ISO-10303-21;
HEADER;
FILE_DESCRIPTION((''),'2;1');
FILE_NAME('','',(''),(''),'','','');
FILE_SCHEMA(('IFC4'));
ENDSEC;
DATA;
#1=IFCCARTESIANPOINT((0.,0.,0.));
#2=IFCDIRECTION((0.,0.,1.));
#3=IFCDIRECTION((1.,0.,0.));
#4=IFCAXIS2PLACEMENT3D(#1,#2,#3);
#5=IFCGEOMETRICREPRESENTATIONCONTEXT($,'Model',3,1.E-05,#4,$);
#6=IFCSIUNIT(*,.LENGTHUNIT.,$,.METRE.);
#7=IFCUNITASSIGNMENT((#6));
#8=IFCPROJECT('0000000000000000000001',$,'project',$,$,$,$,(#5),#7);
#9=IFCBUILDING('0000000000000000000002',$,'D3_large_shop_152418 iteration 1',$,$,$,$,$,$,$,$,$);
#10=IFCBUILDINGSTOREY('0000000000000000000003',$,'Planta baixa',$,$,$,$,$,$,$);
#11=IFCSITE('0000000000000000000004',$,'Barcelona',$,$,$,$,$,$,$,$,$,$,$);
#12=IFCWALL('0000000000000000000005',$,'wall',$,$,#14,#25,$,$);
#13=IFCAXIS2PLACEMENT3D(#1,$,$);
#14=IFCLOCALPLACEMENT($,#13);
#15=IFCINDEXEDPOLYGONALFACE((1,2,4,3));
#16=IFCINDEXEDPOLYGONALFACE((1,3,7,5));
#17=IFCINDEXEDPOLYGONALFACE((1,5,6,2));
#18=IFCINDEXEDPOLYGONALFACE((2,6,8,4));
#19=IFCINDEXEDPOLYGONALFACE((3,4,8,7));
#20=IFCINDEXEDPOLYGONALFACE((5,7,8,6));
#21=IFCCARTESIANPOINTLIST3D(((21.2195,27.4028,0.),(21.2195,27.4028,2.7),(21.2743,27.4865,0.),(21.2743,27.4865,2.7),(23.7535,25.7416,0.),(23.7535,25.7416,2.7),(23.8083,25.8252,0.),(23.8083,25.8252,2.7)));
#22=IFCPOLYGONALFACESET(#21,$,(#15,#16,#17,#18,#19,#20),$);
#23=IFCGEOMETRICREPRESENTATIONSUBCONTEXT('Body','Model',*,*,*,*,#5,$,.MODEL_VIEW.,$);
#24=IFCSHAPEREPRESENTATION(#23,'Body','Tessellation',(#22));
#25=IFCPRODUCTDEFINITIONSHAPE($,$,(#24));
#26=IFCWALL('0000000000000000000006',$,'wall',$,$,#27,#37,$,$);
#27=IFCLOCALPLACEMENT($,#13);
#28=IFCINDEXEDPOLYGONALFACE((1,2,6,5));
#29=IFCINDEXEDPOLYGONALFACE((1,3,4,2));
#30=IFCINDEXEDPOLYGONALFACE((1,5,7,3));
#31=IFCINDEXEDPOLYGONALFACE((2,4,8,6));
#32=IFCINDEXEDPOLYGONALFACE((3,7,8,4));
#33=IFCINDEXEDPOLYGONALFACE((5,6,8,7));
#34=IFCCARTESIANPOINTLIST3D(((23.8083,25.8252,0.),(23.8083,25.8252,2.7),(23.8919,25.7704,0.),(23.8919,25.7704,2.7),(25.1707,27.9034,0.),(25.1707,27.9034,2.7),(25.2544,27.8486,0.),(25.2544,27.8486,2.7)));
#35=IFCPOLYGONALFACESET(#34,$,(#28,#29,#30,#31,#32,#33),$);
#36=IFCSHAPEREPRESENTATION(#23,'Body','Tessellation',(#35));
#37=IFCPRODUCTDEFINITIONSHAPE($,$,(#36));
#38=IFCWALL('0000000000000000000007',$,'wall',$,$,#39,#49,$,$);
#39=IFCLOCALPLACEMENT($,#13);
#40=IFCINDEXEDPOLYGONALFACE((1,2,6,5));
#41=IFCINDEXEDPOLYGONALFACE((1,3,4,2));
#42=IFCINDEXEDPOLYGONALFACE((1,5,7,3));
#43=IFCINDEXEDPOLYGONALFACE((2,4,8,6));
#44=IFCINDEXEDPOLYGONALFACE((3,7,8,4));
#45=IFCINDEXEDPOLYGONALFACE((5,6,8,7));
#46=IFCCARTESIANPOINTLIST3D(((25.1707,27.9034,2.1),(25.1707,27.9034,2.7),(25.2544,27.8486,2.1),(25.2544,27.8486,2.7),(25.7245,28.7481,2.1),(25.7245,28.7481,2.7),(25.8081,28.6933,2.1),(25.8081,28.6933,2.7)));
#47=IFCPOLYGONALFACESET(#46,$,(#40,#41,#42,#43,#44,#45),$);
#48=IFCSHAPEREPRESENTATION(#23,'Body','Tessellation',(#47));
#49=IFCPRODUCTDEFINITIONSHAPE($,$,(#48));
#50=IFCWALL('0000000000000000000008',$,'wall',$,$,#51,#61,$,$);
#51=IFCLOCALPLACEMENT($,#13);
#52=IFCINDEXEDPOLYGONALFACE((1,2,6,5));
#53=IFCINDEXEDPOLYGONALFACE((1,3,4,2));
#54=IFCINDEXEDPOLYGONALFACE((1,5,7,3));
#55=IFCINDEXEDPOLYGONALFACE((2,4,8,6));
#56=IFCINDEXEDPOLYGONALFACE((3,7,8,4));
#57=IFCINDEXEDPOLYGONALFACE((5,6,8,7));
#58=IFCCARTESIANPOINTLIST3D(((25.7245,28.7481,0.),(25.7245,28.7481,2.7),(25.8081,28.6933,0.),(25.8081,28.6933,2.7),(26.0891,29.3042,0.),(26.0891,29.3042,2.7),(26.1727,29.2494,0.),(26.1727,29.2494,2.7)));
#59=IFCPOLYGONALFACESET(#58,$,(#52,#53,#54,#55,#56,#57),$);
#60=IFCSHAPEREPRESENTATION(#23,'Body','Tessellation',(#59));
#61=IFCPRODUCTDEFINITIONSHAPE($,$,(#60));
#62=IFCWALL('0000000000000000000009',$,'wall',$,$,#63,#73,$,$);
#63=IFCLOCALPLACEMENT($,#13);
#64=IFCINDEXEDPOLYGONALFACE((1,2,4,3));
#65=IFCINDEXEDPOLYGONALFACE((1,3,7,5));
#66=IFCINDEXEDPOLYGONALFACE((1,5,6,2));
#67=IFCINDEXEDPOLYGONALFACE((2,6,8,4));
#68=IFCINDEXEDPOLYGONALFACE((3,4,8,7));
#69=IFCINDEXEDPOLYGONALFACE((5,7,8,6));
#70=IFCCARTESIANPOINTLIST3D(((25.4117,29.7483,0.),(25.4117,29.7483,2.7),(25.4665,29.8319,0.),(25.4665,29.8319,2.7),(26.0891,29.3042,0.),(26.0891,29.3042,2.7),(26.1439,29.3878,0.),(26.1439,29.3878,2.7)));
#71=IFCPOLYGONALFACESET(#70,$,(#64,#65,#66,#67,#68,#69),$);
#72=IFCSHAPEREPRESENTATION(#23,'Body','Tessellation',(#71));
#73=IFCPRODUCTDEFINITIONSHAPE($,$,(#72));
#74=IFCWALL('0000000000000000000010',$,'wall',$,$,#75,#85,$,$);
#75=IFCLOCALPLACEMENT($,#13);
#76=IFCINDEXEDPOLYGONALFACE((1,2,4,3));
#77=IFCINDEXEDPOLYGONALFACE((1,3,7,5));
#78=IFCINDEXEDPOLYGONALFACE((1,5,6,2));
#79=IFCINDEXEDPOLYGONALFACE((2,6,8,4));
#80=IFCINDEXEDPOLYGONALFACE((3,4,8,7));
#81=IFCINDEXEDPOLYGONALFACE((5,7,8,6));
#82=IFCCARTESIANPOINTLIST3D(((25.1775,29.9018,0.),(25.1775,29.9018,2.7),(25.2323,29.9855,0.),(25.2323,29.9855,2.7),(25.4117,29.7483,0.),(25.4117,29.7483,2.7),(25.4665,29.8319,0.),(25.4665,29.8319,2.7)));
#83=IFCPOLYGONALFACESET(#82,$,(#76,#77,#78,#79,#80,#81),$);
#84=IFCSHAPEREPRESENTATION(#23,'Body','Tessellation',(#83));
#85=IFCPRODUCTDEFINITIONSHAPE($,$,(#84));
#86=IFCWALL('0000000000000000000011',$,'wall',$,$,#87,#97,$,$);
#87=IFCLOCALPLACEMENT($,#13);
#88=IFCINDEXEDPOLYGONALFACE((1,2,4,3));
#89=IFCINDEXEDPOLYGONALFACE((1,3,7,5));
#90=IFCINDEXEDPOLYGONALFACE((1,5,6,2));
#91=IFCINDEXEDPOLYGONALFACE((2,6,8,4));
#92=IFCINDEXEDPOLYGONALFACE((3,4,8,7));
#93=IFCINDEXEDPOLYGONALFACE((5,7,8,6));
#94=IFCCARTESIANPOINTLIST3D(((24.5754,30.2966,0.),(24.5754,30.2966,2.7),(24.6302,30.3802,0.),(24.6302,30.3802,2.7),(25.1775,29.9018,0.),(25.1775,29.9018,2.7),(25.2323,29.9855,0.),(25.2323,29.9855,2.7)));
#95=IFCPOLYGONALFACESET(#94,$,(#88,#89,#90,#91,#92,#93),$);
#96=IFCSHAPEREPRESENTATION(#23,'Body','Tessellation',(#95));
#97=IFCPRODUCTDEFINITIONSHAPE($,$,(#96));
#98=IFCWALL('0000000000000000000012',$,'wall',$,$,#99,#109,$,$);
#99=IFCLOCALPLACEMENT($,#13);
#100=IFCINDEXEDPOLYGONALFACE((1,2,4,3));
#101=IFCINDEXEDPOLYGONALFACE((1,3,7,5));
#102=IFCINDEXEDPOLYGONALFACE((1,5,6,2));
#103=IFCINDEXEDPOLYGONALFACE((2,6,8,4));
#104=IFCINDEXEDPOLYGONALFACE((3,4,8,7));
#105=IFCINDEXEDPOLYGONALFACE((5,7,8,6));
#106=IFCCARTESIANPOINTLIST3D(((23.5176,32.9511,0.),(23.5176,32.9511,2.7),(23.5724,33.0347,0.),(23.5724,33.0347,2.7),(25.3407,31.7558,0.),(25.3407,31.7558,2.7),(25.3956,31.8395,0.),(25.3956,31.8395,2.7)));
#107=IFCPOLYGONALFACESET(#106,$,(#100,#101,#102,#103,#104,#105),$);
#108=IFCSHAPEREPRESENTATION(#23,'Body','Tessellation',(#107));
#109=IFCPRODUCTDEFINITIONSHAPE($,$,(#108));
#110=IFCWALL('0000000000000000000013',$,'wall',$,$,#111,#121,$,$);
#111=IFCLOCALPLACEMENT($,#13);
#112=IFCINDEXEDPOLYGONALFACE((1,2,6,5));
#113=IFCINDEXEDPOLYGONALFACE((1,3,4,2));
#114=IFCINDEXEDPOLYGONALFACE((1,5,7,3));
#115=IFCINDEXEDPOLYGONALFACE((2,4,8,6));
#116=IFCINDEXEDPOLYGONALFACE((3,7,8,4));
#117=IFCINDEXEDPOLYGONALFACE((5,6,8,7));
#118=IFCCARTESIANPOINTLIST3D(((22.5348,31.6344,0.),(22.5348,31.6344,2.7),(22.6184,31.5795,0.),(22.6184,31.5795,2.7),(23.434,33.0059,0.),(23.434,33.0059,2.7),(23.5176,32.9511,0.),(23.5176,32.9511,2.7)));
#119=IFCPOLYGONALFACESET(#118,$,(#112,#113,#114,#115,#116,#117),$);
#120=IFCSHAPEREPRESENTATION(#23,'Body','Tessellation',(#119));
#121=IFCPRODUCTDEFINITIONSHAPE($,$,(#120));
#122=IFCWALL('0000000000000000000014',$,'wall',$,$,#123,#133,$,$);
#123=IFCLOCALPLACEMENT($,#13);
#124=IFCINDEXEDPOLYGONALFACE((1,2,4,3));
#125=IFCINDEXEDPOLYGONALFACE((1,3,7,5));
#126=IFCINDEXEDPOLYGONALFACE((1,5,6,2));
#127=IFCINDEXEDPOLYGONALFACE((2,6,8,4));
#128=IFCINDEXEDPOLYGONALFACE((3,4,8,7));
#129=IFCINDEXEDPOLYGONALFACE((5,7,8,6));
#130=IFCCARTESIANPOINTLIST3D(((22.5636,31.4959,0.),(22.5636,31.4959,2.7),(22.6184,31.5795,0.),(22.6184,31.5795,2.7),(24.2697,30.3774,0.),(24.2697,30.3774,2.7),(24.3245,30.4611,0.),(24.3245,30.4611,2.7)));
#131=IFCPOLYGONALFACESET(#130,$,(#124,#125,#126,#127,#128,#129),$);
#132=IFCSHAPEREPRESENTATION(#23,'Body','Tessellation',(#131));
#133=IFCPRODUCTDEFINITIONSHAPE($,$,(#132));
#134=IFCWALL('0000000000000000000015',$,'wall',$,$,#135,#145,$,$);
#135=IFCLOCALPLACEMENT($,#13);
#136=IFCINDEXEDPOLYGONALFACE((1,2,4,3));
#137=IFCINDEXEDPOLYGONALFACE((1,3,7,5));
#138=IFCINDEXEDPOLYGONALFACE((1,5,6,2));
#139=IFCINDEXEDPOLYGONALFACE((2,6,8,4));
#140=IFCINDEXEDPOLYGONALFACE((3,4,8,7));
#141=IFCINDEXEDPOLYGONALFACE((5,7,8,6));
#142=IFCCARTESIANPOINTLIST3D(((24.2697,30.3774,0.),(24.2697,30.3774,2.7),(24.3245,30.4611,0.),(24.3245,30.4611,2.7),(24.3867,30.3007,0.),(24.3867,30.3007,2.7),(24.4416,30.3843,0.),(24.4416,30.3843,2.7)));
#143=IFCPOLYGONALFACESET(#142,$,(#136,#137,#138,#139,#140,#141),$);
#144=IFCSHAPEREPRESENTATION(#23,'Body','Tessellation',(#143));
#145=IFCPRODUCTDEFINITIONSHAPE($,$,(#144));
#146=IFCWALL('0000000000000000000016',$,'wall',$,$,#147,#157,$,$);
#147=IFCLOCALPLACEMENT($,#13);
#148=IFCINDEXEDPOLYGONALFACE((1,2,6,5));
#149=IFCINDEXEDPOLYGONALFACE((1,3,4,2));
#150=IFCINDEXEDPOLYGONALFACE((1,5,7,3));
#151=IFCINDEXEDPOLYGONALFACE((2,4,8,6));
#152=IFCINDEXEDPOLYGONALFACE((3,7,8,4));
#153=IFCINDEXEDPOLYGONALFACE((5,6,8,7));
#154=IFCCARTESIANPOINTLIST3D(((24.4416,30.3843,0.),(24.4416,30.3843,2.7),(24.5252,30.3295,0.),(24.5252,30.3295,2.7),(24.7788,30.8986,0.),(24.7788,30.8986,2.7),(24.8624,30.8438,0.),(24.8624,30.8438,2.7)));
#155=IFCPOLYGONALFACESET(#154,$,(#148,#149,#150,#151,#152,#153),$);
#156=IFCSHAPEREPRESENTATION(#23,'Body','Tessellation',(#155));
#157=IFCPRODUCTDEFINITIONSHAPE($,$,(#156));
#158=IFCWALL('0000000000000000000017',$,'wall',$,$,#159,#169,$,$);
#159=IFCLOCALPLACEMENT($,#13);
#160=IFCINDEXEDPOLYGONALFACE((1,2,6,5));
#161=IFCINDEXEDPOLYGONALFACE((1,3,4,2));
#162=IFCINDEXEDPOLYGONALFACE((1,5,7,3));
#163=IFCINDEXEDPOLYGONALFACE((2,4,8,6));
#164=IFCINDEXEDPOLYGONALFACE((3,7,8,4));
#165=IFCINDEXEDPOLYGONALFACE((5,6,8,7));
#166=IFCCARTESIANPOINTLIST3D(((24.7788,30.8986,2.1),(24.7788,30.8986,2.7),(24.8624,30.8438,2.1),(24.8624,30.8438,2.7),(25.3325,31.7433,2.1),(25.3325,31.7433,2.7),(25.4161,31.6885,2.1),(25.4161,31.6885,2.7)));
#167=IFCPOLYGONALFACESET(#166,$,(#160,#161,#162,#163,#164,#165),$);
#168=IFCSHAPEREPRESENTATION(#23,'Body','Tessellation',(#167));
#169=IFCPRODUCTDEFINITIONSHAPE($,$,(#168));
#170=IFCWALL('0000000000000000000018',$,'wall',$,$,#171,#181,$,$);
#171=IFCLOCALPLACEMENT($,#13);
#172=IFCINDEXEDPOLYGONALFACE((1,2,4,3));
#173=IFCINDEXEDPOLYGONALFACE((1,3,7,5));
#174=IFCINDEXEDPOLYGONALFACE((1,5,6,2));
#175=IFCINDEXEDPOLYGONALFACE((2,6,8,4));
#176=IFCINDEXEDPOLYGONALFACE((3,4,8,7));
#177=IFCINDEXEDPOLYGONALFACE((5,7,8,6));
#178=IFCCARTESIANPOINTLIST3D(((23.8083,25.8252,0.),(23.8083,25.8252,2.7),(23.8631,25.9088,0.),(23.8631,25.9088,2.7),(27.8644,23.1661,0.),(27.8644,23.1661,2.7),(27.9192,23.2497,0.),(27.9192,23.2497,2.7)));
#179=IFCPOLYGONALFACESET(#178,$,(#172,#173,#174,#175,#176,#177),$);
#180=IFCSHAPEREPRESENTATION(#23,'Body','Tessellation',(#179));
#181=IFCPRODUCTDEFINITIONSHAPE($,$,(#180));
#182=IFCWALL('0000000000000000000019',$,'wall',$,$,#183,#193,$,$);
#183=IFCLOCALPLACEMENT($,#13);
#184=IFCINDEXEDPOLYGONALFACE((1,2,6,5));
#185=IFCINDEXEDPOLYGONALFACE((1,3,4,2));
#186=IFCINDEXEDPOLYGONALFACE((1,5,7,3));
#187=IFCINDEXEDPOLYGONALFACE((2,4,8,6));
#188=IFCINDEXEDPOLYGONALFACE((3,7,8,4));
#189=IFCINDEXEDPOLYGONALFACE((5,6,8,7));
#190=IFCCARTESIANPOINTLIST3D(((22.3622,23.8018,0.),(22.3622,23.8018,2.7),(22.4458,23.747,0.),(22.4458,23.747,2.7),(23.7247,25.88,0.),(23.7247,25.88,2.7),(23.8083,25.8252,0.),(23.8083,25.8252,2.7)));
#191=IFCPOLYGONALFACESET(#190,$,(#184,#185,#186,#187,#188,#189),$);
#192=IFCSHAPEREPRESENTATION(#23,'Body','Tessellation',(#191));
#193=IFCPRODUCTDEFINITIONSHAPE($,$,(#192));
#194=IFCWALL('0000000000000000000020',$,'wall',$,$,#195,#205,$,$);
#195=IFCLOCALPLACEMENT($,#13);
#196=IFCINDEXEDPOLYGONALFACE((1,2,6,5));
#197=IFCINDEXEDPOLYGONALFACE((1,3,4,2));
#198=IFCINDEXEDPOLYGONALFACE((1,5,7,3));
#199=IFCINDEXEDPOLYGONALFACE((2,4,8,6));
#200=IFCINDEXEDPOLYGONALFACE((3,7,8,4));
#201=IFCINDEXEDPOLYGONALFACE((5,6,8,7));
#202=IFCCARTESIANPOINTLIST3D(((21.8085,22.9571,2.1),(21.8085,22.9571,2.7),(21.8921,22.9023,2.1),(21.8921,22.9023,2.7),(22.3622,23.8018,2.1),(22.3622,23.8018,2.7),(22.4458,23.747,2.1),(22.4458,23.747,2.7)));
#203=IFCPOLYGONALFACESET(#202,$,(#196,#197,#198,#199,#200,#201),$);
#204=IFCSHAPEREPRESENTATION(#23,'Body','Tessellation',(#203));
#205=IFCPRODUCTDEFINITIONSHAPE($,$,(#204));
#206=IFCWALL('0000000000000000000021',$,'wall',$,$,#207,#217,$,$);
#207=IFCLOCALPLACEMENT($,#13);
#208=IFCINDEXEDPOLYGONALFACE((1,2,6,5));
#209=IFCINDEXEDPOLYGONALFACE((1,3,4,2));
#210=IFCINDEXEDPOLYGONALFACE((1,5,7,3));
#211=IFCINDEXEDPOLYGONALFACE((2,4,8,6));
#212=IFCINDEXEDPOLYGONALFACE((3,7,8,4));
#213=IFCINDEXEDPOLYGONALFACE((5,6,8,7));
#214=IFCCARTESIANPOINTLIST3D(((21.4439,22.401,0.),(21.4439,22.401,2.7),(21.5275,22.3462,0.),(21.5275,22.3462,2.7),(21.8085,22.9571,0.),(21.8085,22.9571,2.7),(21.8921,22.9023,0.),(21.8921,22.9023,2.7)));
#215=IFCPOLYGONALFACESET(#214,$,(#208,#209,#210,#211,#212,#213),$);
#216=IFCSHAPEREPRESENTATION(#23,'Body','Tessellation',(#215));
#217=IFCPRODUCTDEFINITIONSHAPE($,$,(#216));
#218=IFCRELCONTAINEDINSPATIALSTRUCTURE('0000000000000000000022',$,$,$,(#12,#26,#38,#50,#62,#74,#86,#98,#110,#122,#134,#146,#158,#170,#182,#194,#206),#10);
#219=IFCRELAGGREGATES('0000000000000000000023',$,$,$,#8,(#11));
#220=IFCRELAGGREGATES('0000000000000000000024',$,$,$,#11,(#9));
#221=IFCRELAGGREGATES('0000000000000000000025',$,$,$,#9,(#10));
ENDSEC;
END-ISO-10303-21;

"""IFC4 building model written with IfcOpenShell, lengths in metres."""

from ifc_helpers import new_model, si_unit, frame, origin, origin_with_axes, place, context, subcontext, project, spatial, polyline, outline, extrude, element, save


model = new_model("IFC4")

# Units and contexts
model_context = context("Model", 3, precision=1e-05, world=origin_with_axes())
body_context = subcontext(model_context, "Body", "Model", "MODEL_VIEW")
ifc_project = project(units=[si_unit("LENGTHUNIT", "METRE")], contexts=[model_context])

# Site, building, storey
site = spatial("IfcSite", under=ifc_project, Name="Barcelona")
building = spatial("IfcBuilding", under=site, Name="D3_large_shop_152418 iteration 1")
storey = spatial("IfcBuildingStorey", under=building, Name="Planta baixa")

# Walls
wall_1_placement = place(None, origin_with_axes())
element("IfcWall", 1, at=wall_1_placement, inside=storey, Name="wall", context=body_context, shape_type="SweptSolid", body=[
    extrude(outline(polyline([(21.2743, 27.4865), (23.8083, 25.8252), (23.7535, 25.7416), (21.2195, 27.4028), (21.2743, 27.4865)])), origin(), (0.0, 0.0, 1.0), 2.7),
])
wall_2_placement = place(None, origin_with_axes())
element("IfcWall", 2, at=wall_2_placement, inside=storey, Name="wall", context=body_context, shape_type="SweptSolid", body=[
    extrude(outline(polyline([(23.8083, 25.8252), (25.1707, 27.9034), (25.2544, 27.8486), (23.8919, 25.7704), (23.8083, 25.8252)])), origin(), (0.0, 0.0, 1.0), 2.7),
])
wall_3_placement = place(None, origin_with_axes())
element("IfcWall", 3, at=wall_3_placement, inside=storey, Name="wall", context=body_context, shape_type="SweptSolid", body=[
    extrude(outline(polyline([(25.1707, 27.9034), (25.7245, 28.7481), (25.8081, 28.6933), (25.2544, 27.8486), (25.1707, 27.9034)])), frame((0.0, 0.0, 2.1)), (0.0, 0.0, 1.0), 0.6),
])
wall_4_placement = place(None, origin_with_axes())
element("IfcWall", 4, at=wall_4_placement, inside=storey, Name="wall", context=body_context, shape_type="SweptSolid", body=[
    extrude(outline(polyline([(25.7245, 28.7481), (26.0891, 29.3042), (26.1727, 29.2494), (25.8081, 28.6933), (25.7245, 28.7481)])), origin(), (0.0, 0.0, 1.0), 2.7),
])
wall_5_placement = place(None, origin_with_axes())
element("IfcWall", 5, at=wall_5_placement, inside=storey, Name="wall", context=body_context, shape_type="SweptSolid", body=[
    extrude(outline(polyline([(26.0891, 29.3042), (25.4117, 29.7483), (25.4665, 29.8319), (26.1439, 29.3878), (26.0891, 29.3042)])), origin(), (0.0, 0.0, 1.0), 2.7),
])
wall_6_placement = place(None, origin_with_axes())
element("IfcWall", 6, at=wall_6_placement, inside=storey, Name="wall", context=body_context, shape_type="SweptSolid", body=[
    extrude(outline(polyline([(25.4117, 29.7483), (25.1775, 29.9018), (25.2323, 29.9855), (25.4665, 29.8319), (25.4117, 29.7483)])), origin(), (0.0, 0.0, 1.0), 2.7),
])
wall_7_placement = place(None, origin_with_axes())
element("IfcWall", 7, at=wall_7_placement, inside=storey, Name="wall", context=body_context, shape_type="SweptSolid", body=[
    extrude(outline(polyline([(25.1775, 29.9018), (24.5754, 30.2966), (24.6302, 30.3802), (25.2323, 29.9855), (25.1775, 29.9018)])), origin(), (0.0, 0.0, 1.0), 2.7),
])
wall_8_placement = place(None, origin_with_axes())
element("IfcWall", 8, at=wall_8_placement, inside=storey, Name="wall", context=body_context, shape_type="SweptSolid", body=[
    extrude(outline(polyline([(25.3407, 31.7558), (23.5176, 32.9511), (23.5724, 33.0347), (25.3956, 31.8395), (25.3407, 31.7558)])), origin(), (0.0, 0.0, 1.0), 2.7),
])
wall_9_placement = place(None, origin_with_axes())
element("IfcWall", 9, at=wall_9_placement, inside=storey, Name="wall", context=body_context, shape_type="SweptSolid", body=[
    extrude(outline(polyline([(23.5176, 32.9511), (22.6184, 31.5795), (22.5348, 31.6344), (23.434, 33.0059), (23.5176, 32.9511)])), origin(), (0.0, 0.0, 1.0), 2.7),
])
wall_10_placement = place(None, origin_with_axes())
element("IfcWall", 10, at=wall_10_placement, inside=storey, Name="wall", context=body_context, shape_type="SweptSolid", body=[
    extrude(outline(polyline([(22.6184, 31.5795), (24.3245, 30.4611), (24.2697, 30.3774), (22.5636, 31.4959), (22.6184, 31.5795)])), origin(), (0.0, 0.0, 1.0), 2.7),
])
wall_11_placement = place(None, origin_with_axes())
element("IfcWall", 11, at=wall_11_placement, inside=storey, Name="wall", context=body_context, shape_type="SweptSolid", body=[
    extrude(outline(polyline([(24.3245, 30.4611), (24.4416, 30.3843), (24.3867, 30.3007), (24.2697, 30.3774), (24.3245, 30.4611)])), origin(), (0.0, 0.0, 1.0), 2.7),
])
wall_12_placement = place(None, origin_with_axes())
element("IfcWall", 12, at=wall_12_placement, inside=storey, Name="wall", context=body_context, shape_type="SweptSolid", body=[
    extrude(outline(polyline([(24.4416, 30.3843), (24.7788, 30.8986), (24.8624, 30.8438), (24.5252, 30.3295), (24.4416, 30.3843)])), origin(), (0.0, 0.0, 1.0), 2.7),
])
wall_13_placement = place(None, origin_with_axes())
element("IfcWall", 13, at=wall_13_placement, inside=storey, Name="wall", context=body_context, shape_type="SweptSolid", body=[
    extrude(outline(polyline([(24.7788, 30.8986), (25.3325, 31.7433), (25.4161, 31.6885), (24.8624, 30.8438), (24.7788, 30.8986)])), frame((0.0, 0.0, 2.1)), (0.0, 0.0, 1.0), 0.6),
])
wall_14_placement = place(None, origin_with_axes())
element("IfcWall", 14, at=wall_14_placement, inside=storey, Name="wall", context=body_context, shape_type="SweptSolid", body=[
    extrude(outline(polyline([(27.8644, 23.1661), (23.8083, 25.8252), (23.8631, 25.9088), (27.9192, 23.2497), (27.8644, 23.1661)])), origin(), (0.0, 0.0, 1.0), 2.7),
])
wall_15_placement = place(None, origin_with_axes())
element("IfcWall", 15, at=wall_15_placement, inside=storey, Name="wall", context=body_context, shape_type="SweptSolid", body=[
    extrude(outline(polyline([(23.8083, 25.8252), (22.4458, 23.747), (22.3622, 23.8018), (23.7247, 25.88), (23.8083, 25.8252)])), origin(), (0.0, 0.0, 1.0), 2.7),
])
wall_16_placement = place(None, origin_with_axes())
element("IfcWall", 16, at=wall_16_placement, inside=storey, Name="wall", context=body_context, shape_type="SweptSolid", body=[
    extrude(outline(polyline([(22.4458, 23.747), (21.8921, 22.9023), (21.8085, 22.9571), (22.3622, 23.8018), (22.4458, 23.747)])), frame((0.0, 0.0, 2.1)), (0.0, 0.0, 1.0), 0.6),
])
wall_17_placement = place(None, origin_with_axes())
element("IfcWall", 17, at=wall_17_placement, inside=storey, Name="wall", context=body_context, shape_type="SweptSolid", body=[
    extrude(outline(polyline([(21.8921, 22.9023), (21.5275, 22.3462), (21.4439, 22.401), (21.8085, 22.9571), (21.8921, 22.9023)])), origin(), (0.0, 0.0, 1.0), 2.7),
])

save(model, "model.ifc")
